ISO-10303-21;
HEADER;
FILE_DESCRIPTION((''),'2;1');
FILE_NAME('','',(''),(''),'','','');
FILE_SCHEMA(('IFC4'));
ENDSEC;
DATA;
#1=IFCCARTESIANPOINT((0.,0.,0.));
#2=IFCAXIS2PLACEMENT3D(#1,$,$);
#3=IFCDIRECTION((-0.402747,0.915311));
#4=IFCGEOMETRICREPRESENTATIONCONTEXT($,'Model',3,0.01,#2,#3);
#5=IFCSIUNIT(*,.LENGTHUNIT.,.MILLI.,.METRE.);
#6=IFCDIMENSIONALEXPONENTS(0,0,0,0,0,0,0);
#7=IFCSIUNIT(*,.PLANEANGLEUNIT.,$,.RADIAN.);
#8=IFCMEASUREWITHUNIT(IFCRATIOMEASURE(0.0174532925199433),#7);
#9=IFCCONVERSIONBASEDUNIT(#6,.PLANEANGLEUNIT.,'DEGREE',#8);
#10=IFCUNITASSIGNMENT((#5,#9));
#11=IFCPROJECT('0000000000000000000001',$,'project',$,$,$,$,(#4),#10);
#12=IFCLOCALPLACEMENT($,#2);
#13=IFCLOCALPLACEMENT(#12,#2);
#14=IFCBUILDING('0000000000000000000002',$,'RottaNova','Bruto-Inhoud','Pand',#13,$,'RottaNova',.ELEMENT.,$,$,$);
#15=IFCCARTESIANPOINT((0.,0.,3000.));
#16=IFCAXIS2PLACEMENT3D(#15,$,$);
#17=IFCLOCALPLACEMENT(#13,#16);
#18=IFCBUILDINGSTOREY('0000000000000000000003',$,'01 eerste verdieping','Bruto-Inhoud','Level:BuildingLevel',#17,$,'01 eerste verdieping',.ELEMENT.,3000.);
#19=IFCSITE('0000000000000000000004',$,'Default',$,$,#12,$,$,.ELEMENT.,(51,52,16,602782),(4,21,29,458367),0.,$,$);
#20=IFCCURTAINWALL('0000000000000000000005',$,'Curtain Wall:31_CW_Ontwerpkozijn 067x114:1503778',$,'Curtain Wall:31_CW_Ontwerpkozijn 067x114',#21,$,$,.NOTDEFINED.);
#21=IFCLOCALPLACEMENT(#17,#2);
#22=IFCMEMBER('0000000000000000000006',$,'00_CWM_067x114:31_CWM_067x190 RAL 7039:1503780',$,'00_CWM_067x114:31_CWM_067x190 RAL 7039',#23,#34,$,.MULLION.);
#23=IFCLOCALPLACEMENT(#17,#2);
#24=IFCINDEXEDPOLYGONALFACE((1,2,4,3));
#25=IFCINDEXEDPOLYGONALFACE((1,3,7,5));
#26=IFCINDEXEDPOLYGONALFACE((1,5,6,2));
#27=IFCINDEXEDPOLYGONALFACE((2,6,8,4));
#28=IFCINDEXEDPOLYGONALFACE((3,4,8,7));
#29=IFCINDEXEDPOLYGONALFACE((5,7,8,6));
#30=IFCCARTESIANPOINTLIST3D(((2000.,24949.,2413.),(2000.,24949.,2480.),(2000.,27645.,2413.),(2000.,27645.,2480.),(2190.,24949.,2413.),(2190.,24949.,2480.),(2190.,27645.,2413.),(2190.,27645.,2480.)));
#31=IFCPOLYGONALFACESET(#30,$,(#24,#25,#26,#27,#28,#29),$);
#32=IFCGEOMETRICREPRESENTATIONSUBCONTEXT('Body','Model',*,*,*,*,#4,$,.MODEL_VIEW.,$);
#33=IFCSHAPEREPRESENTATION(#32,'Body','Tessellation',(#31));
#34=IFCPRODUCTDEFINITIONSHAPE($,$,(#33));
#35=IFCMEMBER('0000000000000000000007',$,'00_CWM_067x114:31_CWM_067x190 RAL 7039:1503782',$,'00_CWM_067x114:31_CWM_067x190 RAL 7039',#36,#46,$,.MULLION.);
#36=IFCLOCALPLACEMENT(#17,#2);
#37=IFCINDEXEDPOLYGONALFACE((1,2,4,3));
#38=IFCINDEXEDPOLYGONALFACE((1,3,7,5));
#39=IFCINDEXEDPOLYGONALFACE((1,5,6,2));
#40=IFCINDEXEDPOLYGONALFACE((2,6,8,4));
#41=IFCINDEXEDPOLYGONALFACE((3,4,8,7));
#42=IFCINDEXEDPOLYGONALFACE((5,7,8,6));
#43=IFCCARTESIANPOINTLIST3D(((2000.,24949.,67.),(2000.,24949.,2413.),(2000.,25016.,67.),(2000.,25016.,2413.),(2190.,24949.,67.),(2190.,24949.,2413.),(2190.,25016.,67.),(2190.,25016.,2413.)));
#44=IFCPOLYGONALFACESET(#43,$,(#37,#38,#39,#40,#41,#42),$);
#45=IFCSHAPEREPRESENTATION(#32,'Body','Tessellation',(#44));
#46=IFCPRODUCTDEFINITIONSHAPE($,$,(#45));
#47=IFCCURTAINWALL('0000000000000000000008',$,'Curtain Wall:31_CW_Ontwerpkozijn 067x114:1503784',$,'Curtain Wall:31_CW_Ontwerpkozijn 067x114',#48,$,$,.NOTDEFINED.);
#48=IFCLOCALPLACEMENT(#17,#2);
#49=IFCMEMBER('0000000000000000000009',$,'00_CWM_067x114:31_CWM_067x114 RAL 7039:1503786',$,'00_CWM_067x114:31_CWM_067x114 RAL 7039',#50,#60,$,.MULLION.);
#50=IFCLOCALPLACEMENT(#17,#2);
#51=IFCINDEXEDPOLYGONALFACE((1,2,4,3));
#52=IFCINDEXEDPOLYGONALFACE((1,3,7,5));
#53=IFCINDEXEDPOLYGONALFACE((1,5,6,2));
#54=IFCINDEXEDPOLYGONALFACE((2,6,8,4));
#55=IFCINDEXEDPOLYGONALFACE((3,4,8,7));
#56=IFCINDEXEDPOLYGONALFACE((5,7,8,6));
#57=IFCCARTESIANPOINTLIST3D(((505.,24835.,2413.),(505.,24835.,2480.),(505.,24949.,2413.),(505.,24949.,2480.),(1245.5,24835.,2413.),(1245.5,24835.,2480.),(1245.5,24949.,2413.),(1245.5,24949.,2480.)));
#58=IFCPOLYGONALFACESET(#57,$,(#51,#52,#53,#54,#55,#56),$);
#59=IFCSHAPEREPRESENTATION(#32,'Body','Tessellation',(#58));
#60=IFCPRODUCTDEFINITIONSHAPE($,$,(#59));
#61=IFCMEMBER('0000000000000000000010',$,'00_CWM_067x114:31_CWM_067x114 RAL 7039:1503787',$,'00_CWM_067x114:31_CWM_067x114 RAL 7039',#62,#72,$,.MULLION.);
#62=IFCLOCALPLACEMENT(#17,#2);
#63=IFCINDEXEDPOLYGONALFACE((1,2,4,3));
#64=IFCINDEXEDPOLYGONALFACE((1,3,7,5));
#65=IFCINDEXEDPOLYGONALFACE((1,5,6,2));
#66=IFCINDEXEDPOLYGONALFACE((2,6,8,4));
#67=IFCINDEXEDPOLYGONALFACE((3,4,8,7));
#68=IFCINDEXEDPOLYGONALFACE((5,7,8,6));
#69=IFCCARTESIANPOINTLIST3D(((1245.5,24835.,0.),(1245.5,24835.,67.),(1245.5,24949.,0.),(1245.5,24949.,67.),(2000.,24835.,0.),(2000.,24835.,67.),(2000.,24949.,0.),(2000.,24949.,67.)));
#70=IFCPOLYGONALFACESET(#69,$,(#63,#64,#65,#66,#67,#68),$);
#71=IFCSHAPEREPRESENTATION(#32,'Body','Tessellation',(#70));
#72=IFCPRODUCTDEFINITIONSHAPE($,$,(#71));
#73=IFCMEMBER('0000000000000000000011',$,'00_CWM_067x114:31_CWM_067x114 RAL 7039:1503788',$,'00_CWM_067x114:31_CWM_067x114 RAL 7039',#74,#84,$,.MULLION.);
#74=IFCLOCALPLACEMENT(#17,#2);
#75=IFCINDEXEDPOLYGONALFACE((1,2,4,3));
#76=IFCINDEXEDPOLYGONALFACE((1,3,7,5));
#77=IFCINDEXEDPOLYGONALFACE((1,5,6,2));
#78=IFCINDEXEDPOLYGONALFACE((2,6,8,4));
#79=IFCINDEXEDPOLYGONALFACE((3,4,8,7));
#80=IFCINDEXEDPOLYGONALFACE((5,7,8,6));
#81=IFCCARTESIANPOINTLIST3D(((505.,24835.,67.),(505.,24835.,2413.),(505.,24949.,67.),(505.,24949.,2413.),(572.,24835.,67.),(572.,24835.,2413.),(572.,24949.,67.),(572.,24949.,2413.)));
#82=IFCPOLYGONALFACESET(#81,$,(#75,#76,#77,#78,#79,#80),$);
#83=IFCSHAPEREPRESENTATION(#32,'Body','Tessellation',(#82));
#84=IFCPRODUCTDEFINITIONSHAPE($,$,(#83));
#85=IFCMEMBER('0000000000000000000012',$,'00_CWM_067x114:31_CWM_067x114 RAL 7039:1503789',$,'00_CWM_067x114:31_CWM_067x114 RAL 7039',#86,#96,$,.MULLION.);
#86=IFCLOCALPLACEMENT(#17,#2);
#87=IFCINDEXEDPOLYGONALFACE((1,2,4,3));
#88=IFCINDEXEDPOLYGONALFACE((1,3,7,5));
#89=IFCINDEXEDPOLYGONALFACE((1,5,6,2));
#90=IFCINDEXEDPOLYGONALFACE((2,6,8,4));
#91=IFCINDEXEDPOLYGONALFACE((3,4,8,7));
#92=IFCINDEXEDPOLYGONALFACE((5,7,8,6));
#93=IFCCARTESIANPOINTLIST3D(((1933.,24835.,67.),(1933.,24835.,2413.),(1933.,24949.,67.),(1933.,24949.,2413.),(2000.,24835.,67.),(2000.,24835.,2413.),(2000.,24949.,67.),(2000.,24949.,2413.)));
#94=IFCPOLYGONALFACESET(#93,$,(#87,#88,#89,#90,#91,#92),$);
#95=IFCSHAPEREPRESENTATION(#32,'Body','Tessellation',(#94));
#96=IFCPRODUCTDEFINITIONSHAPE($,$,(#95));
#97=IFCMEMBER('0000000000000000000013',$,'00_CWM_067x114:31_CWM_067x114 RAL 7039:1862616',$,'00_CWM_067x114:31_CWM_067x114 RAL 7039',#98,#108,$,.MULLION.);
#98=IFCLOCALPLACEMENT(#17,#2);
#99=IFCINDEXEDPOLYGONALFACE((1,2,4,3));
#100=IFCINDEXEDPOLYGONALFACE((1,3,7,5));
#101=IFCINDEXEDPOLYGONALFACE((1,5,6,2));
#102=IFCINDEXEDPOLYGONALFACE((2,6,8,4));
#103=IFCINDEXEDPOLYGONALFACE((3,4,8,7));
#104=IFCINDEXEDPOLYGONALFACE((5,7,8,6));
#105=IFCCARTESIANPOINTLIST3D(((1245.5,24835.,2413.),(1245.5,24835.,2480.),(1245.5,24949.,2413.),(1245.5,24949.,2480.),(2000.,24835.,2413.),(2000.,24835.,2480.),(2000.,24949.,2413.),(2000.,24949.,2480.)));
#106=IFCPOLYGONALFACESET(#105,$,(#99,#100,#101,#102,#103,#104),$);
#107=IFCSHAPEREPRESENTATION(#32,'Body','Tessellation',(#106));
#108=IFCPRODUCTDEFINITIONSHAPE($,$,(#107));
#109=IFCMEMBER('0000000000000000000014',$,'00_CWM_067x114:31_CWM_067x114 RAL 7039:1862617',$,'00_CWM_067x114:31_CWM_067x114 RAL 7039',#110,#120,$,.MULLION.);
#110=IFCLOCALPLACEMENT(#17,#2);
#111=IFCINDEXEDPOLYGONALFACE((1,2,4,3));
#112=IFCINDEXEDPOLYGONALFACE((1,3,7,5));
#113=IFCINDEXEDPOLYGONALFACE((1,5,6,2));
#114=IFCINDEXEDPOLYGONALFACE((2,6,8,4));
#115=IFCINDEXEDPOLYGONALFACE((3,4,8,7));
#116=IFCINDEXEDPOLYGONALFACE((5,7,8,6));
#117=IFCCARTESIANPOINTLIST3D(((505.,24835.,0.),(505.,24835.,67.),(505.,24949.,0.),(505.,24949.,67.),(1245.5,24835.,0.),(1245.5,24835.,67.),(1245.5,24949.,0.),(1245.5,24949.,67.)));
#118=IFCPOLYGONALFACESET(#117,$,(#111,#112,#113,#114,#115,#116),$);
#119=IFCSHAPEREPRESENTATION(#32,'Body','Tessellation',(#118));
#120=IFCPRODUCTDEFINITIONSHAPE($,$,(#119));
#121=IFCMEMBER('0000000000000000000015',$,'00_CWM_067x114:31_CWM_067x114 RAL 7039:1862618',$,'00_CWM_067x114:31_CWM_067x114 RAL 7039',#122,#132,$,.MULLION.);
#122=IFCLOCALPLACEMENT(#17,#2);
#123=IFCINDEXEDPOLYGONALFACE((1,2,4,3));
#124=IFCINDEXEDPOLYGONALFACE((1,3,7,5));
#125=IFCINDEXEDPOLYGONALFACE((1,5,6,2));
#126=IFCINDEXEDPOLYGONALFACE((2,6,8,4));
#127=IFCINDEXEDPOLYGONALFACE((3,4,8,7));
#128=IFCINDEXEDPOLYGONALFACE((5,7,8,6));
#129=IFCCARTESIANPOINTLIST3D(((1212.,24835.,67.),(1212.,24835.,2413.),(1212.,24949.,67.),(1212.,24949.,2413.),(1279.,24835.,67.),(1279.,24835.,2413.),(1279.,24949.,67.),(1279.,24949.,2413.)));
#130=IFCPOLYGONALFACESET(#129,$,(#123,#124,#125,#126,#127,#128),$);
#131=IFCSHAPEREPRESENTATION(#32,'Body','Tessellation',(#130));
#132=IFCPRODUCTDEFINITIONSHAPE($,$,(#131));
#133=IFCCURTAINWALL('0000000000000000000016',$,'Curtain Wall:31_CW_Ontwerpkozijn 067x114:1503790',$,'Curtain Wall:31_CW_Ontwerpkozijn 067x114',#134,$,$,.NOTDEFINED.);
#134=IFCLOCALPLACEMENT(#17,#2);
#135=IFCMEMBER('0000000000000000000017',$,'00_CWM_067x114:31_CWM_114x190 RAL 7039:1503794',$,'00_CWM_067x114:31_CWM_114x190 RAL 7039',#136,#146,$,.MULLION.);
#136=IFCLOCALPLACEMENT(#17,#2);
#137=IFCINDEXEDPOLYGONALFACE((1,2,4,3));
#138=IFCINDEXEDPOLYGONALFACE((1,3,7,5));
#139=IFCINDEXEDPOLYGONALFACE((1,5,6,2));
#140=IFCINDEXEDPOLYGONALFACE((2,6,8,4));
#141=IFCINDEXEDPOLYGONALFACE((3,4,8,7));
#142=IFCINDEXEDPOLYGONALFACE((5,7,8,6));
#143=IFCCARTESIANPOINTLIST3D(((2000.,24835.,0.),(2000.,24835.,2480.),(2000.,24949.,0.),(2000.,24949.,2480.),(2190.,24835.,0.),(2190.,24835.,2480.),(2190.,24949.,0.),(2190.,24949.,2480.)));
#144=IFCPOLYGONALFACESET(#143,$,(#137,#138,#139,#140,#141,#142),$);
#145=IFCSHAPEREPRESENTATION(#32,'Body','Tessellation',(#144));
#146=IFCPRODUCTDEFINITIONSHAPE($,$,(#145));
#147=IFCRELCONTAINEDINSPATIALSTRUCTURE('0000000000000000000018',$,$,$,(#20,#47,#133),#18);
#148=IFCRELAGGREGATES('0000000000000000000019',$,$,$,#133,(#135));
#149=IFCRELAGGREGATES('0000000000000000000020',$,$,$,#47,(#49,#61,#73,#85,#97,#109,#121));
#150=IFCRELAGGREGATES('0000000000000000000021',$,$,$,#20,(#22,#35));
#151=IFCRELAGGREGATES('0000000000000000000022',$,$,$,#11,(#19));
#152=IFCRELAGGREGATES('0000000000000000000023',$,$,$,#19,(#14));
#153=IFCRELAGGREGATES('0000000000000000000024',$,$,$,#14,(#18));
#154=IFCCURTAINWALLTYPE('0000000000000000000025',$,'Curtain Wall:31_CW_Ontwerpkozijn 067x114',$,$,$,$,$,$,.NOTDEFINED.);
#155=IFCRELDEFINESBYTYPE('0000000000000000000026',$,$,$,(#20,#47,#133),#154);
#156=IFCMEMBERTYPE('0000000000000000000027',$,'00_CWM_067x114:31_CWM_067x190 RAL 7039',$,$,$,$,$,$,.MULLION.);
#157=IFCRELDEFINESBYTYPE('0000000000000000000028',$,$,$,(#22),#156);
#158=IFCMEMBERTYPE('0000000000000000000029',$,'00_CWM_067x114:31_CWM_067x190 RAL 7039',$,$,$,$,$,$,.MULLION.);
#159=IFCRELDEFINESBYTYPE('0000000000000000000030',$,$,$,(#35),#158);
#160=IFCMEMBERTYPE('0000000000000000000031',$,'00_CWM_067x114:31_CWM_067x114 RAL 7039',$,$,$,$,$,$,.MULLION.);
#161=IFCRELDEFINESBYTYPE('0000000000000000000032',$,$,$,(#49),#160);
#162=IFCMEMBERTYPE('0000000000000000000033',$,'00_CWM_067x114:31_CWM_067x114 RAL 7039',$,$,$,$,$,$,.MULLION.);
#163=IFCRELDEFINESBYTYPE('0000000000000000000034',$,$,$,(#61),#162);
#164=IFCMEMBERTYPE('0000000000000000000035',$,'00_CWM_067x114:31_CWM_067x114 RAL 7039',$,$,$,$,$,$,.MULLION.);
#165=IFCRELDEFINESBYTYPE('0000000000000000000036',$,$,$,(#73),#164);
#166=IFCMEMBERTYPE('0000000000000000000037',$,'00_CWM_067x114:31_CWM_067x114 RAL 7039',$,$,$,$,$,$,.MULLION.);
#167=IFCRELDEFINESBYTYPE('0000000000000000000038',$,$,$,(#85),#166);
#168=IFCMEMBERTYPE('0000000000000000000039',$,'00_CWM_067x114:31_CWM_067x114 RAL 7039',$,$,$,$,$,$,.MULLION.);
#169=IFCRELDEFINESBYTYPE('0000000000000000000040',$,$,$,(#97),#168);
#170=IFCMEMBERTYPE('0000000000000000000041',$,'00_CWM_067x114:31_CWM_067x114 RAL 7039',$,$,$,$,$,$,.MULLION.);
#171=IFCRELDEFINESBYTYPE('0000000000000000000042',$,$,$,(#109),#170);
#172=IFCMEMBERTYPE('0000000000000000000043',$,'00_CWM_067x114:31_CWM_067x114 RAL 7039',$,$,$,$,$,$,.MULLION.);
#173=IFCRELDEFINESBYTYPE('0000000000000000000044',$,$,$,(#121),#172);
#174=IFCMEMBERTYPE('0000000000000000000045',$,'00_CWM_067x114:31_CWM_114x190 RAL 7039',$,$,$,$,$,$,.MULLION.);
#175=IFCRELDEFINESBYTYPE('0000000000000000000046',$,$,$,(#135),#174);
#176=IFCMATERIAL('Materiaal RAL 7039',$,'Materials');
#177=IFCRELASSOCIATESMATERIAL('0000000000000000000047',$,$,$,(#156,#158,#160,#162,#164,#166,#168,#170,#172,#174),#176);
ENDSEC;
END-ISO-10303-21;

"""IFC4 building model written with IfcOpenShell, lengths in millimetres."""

from ifc_helpers import new_model, entity, si_unit, converted_unit, direction, frame, origin, origin_2d_with_axis, place, context, subcontext, project, spatial, rectangle, extrude, source, transform, mapped, material, material_profile, profile_set, type_object, type_shapes, element, aggregate, save


model = new_model("IFC4")

# Units and contexts
model_context = context("Model", 3, precision=0.01, world=origin(), true_north=direction((-0.402747, 0.915311)))
body_context = subcontext(model_context, "Body", "Model", "MODEL_VIEW")
ifc_project = project(units=[si_unit("LENGTHUNIT", "METRE", prefix="MILLI"), converted_unit("PLANEANGLEUNIT", "DEGREE", entity("IfcRatioMeasure", 0.0174532925199433), si_unit("PLANEANGLEUNIT", "RADIAN"), dimensions=[0, 0, 0, 0, 0, 0, 0])], contexts=[model_context])

# Site, building, storey
site_placement = place(None, origin())
site = spatial("IfcSite", under=ifc_project, at=site_placement, Name="Default", CompositionType="ELEMENT", RefLatitude=(51, 52, 16, 602782), RefLongitude=(4, 21, 29, 458367), RefElevation=0.0)
building_placement = place(site_placement, origin())
building = spatial("IfcBuilding", under=site, at=building_placement, Name="RottaNova", Description="Bruto-Inhoud", ObjectType="Pand", LongName="RottaNova", CompositionType="ELEMENT")
storey_placement = place(building_placement, frame((0.0, 0.0, 3000.0)))
storey = spatial("IfcBuildingStorey", under=building, at=storey_placement, Name="01 eerste verdieping", Description="Bruto-Inhoud", ObjectType="Level:BuildingLevel", LongName="01 eerste verdieping", CompositionType="ELEMENT", Elevation=3000.0)

# Curtain walls, members
curtain_wall_type = type_object("IfcCurtainWallType", Name="Curtain Wall:31_CW_Ontwerpkozijn 067x114", PredefinedType="NOTDEFINED")
curtain_wall_1_placement = place(storey_placement, frame((0.0, 0.0, -3000.0)))
curtain_wall_1 = element("IfcCurtainWall", 1, at=curtain_wall_1_placement, inside=storey, type_object=curtain_wall_type, Name="Curtain Wall:31_CW_Ontwerpkozijn 067x114:1503778", ObjectType="Curtain Wall:31_CW_Ontwerpkozijn 067x114", PredefinedType="NOTDEFINED")
ifc_material_1 = material(Name="Materiaal RAL 7039", Category="Materials")
ifc_material_profile_1 = material_profile(ifc_material_1, rectangle(XDim=190.0, YDim=67.0, at=origin_2d_with_axis()), Name="31_CWM_067x190 RAL 7039")
ifc_profile_set_1 = profile_set([ifc_material_profile_1], Name="31_CWM_067x190 RAL 7039")
member_type_1 = type_object("IfcMemberType", Name="00_CWM_067x114:31_CWM_067x190 RAL 7039", PredefinedType="MULLION", material=ifc_profile_set_1)
shared_shape_1 = source(origin(), body_context, "Body", "SweptSolid", [
    extrude(rectangle(XDim=190.0, YDim=67.0, at=origin_2d_with_axis()), frame((-33.5, 95.0, -2696.0), z_axis=(0.0, 0.0, 1.0), x_axis=(0.0, -1.0, 0.0)), (0.0, 0.0, 1.0), 2696.0),
])
type_shapes(member_type_1, [shared_shape_1])
member_1_placement = place(curtain_wall_1_placement, frame((2190.0, 24949.0, 5480.0), z_axis=(0.0, -1.0, 0.0), x_axis=(0.0, 0.0, 1.0)))
member_1 = element("IfcMember", 2, at=member_1_placement, type_object=member_type_1, Name="00_CWM_067x114:31_CWM_067x190 RAL 7039:1503780", ObjectType="00_CWM_067x114:31_CWM_067x190 RAL 7039", PredefinedType="MULLION", context=body_context, shape_type="MappedRepresentation", body=[
    mapped(shared_shape_1, transform((0.0, 0.0, 0.0), scale=1.0)),
])
member_type_2 = type_object("IfcMemberType", Name="00_CWM_067x114:31_CWM_067x190 RAL 7039", PredefinedType="MULLION", material=ifc_profile_set_1)
shared_shape_2 = source(origin(), body_context, "Body", "SweptSolid", [
    extrude(rectangle(XDim=190.0, YDim=67.0, at=origin_2d_with_axis()), frame((-33.5, 95.0, -2346.0), z_axis=(0.0, 0.0, 1.0), x_axis=(0.0, -1.0, 0.0)), (0.0, 0.0, 1.0), 2346.0),
])
type_shapes(member_type_2, [shared_shape_2])
member_2_placement = place(curtain_wall_1_placement, frame((2190.0, 24949.0, 3067.0), z_axis=(0.0, 0.0, -1.0), x_axis=(0.0, -1.0, 0.0)))
member_2 = element("IfcMember", 3, at=member_2_placement, type_object=member_type_2, Name="00_CWM_067x114:31_CWM_067x190 RAL 7039:1503782", ObjectType="00_CWM_067x114:31_CWM_067x190 RAL 7039", PredefinedType="MULLION", context=body_context, shape_type="MappedRepresentation", body=[
    mapped(shared_shape_2, transform((0.0, 0.0, 0.0), scale=1.0)),
])
curtain_wall_2_placement = place(storey_placement, frame((0.0, 0.0, -3000.0)))
curtain_wall_2 = element("IfcCurtainWall", 4, at=curtain_wall_2_placement, inside=storey, type_object=curtain_wall_type, Name="Curtain Wall:31_CW_Ontwerpkozijn 067x114:1503784", ObjectType="Curtain Wall:31_CW_Ontwerpkozijn 067x114", PredefinedType="NOTDEFINED")
ifc_material_profile_2 = material_profile(ifc_material_1, rectangle(XDim=114.0, YDim=67.0, at=origin_2d_with_axis()), Name="31_CWM_067x114 RAL 7039")
ifc_profile_set_2 = profile_set([ifc_material_profile_2], Name="31_CWM_067x114 RAL 7039")
member_type_3 = type_object("IfcMemberType", Name="00_CWM_067x114:31_CWM_067x114 RAL 7039", PredefinedType="MULLION", material=ifc_profile_set_2)
shared_shape_3 = source(origin(), body_context, "Body", "SweptSolid", [
    extrude(rectangle(XDim=114.0, YDim=67.0, at=origin_2d_with_axis()), frame((-33.5, 57.0, -740.5), z_axis=(0.0, 0.0, 1.0), x_axis=(0.0, -1.0, 0.0)), (0.0, 0.0, 1.0), 740.5),
])
type_shapes(member_type_3, [shared_shape_3])
member_3_placement = place(curtain_wall_2_placement, frame((505.0, 24835.0, 5480.0), z_axis=(-1.0, 0.0, 0.0), x_axis=(0.0, 0.0, 1.0)))
member_3 = element("IfcMember", 5, at=member_3_placement, type_object=member_type_3, Name="00_CWM_067x114:31_CWM_067x114 RAL 7039:1503786", ObjectType="00_CWM_067x114:31_CWM_067x114 RAL 7039", PredefinedType="MULLION", context=body_context, shape_type="MappedRepresentation", body=[
    mapped(shared_shape_3, transform((0.0, 0.0, 0.0), scale=1.0)),
])
member_type_4 = type_object("IfcMemberType", Name="00_CWM_067x114:31_CWM_067x114 RAL 7039", PredefinedType="MULLION", material=ifc_profile_set_2)
shared_shape_4 = source(origin(), body_context, "Body", "SweptSolid", [
    extrude(rectangle(XDim=114.0, YDim=67.0, at=origin_2d_with_axis()), frame((-33.5, 57.0, -754.5), z_axis=(0.0, 0.0, 1.0), x_axis=(0.0, -1.0, 0.0)), (0.0, 0.0, 1.0), 754.5),
])
type_shapes(member_type_4, [shared_shape_4])
member_4_placement = place(curtain_wall_2_placement, frame((2000.0, 24835.0, 3000.0), z_axis=(1.0, 0.0, 0.0), x_axis=(0.0, 0.0, -1.0)))
member_4 = element("IfcMember", 6, at=member_4_placement, type_object=member_type_4, Name="00_CWM_067x114:31_CWM_067x114 RAL 7039:1503787", ObjectType="00_CWM_067x114:31_CWM_067x114 RAL 7039", PredefinedType="MULLION", context=body_context, shape_type="MappedRepresentation", body=[
    mapped(shared_shape_4, transform((0.0, 0.0, 0.0), scale=1.0)),
])
member_type_5 = type_object("IfcMemberType", Name="00_CWM_067x114:31_CWM_067x114 RAL 7039", PredefinedType="MULLION", material=ifc_profile_set_2)
shared_shape_5 = source(origin(), body_context, "Body", "SweptSolid", [
    extrude(rectangle(XDim=114.0, YDim=67.0, at=origin_2d_with_axis()), frame((-33.5, 57.0, -2346.0), z_axis=(0.0, 0.0, 1.0), x_axis=(0.0, -1.0, 0.0)), (0.0, 0.0, 1.0), 2346.0),
])
type_shapes(member_type_5, [shared_shape_5])
member_5_placement = place(curtain_wall_2_placement, frame((505.0, 24835.0, 3067.0), z_axis=(0.0, 0.0, -1.0), x_axis=(-1.0, 0.0, 0.0)))
member_5 = element("IfcMember", 7, at=member_5_placement, type_object=member_type_5, Name="00_CWM_067x114:31_CWM_067x114 RAL 7039:1503788", ObjectType="00_CWM_067x114:31_CWM_067x114 RAL 7039", PredefinedType="MULLION", context=body_context, shape_type="MappedRepresentation", body=[
    mapped(shared_shape_5, transform((0.0, 0.0, 0.0), scale=1.0)),
])
member_type_6 = type_object("IfcMemberType", Name="00_CWM_067x114:31_CWM_067x114 RAL 7039", PredefinedType="MULLION", material=ifc_profile_set_2)
shared_shape_6 = source(origin(), body_context, "Body", "SweptSolid", [
    extrude(rectangle(XDim=114.0, YDim=67.0, at=origin_2d_with_axis()), frame((-33.5, 57.0, -2346.0), z_axis=(0.0, 0.0, 1.0), x_axis=(0.0, -1.0, 0.0)), (0.0, 0.0, 1.0), 2346.0),
])
type_shapes(member_type_6, [shared_shape_6])
member_6_placement = place(curtain_wall_2_placement, frame((2000.0, 24835.0, 5413.0)))
member_6 = element("IfcMember", 8, at=member_6_placement, type_object=member_type_6, Name="00_CWM_067x114:31_CWM_067x114 RAL 7039:1503789", ObjectType="00_CWM_067x114:31_CWM_067x114 RAL 7039", PredefinedType="MULLION", context=body_context, shape_type="MappedRepresentation", body=[
    mapped(shared_shape_6, transform((0.0, 0.0, 0.0), scale=1.0)),
])
member_type_7 = type_object("IfcMemberType", Name="00_CWM_067x114:31_CWM_067x114 RAL 7039", PredefinedType="MULLION", material=ifc_profile_set_2)
shared_shape_7 = source(origin(), body_context, "Body", "SweptSolid", [
    extrude(rectangle(XDim=114.0, YDim=67.0, at=origin_2d_with_axis()), frame((-33.5, 57.0, -754.5), z_axis=(0.0, 0.0, 1.0), x_axis=(0.0, -1.0, 0.0)), (0.0, 0.0, 1.0), 754.5),
])
type_shapes(member_type_7, [shared_shape_7])
member_7_placement = place(curtain_wall_2_placement, frame((1245.5, 24835.0, 5480.0), z_axis=(-1.0, 0.0, 0.0), x_axis=(0.0, 0.0, 1.0)))
member_7 = element("IfcMember", 9, at=member_7_placement, type_object=member_type_7, Name="00_CWM_067x114:31_CWM_067x114 RAL 7039:1862616", ObjectType="00_CWM_067x114:31_CWM_067x114 RAL 7039", PredefinedType="MULLION", context=body_context, shape_type="MappedRepresentation", body=[
    mapped(shared_shape_7, transform((0.0, 0.0, 0.0), scale=1.0)),
])
member_type_8 = type_object("IfcMemberType", Name="00_CWM_067x114:31_CWM_067x114 RAL 7039", PredefinedType="MULLION", material=ifc_profile_set_2)
shared_shape_8 = source(origin(), body_context, "Body", "SweptSolid", [
    extrude(rectangle(XDim=114.0, YDim=67.0, at=origin_2d_with_axis()), frame((-33.5, 57.0, -740.5), z_axis=(0.0, 0.0, 1.0), x_axis=(0.0, -1.0, 0.0)), (0.0, 0.0, 1.0), 740.5),
])
type_shapes(member_type_8, [shared_shape_8])
member_8_placement = place(curtain_wall_2_placement, frame((1245.5, 24835.0, 3000.0), z_axis=(1.0, 0.0, 0.0), x_axis=(0.0, 0.0, -1.0)))
member_8 = element("IfcMember", 10, at=member_8_placement, type_object=member_type_8, Name="00_CWM_067x114:31_CWM_067x114 RAL 7039:1862617", ObjectType="00_CWM_067x114:31_CWM_067x114 RAL 7039", PredefinedType="MULLION", context=body_context, shape_type="MappedRepresentation", body=[
    mapped(shared_shape_8, transform((0.0, 0.0, 0.0), scale=1.0)),
])
member_type_9 = type_object("IfcMemberType", Name="00_CWM_067x114:31_CWM_067x114 RAL 7039", PredefinedType="MULLION", material=ifc_profile_set_2)
shared_shape_9 = source(origin(), body_context, "Body", "SweptSolid", [
    extrude(rectangle(XDim=114.0, YDim=67.0, at=origin_2d_with_axis()), frame((0.0, 57.0, -2346.0), z_axis=(0.0, 0.0, 1.0), x_axis=(0.0, -1.0, 0.0)), (0.0, 0.0, 1.0), 2346.0),
])
type_shapes(member_type_9, [shared_shape_9])
member_9_placement = place(curtain_wall_2_placement, frame((1245.5, 24835.0, 3067.0), z_axis=(0.0, 0.0, -1.0), x_axis=(-1.0, 0.0, 0.0)))
member_9 = element("IfcMember", 11, at=member_9_placement, type_object=member_type_9, Name="00_CWM_067x114:31_CWM_067x114 RAL 7039:1862618", ObjectType="00_CWM_067x114:31_CWM_067x114 RAL 7039", PredefinedType="MULLION", context=body_context, shape_type="MappedRepresentation", body=[
    mapped(shared_shape_9, transform((0.0, 0.0, 0.0), scale=1.0)),
])

# Curtain wall, member
curtain_wall_3_placement = place(storey_placement, frame((0.0, 0.0, -3000.0)))
curtain_wall_3 = element("IfcCurtainWall", 12, at=curtain_wall_3_placement, inside=storey, type_object=curtain_wall_type, Name="Curtain Wall:31_CW_Ontwerpkozijn 067x114:1503790", ObjectType="Curtain Wall:31_CW_Ontwerpkozijn 067x114", PredefinedType="NOTDEFINED")
ifc_material_profile_3 = material_profile(ifc_material_1, rectangle(XDim=114.0, YDim=190.0, at=origin_2d_with_axis()), Name="31_CWM_114x190 RAL 7039")
ifc_profile_set_3 = profile_set([ifc_material_profile_3], Name="31_CWM_114x190 RAL 7039")
member_type_10 = type_object("IfcMemberType", Name="00_CWM_067x114:31_CWM_114x190 RAL 7039", PredefinedType="MULLION", material=ifc_profile_set_3)
shared_shape_10 = source(origin(), body_context, "Body", "SweptSolid", [
    extrude(rectangle(XDim=114.0, YDim=190.0, at=origin_2d_with_axis()), frame((-95.0, 0.0, -2480.0), z_axis=(0.0, 0.0, 1.0), x_axis=(0.0, -1.0, 0.0)), (0.0, 0.0, 1.0), 2480.0),
])
type_shapes(member_type_10, [shared_shape_10])
member_10_placement = place(curtain_wall_3_placement, frame((2190.0, 24892.0, 5480.0)))
member_10 = element("IfcMember", 13, at=member_10_placement, type_object=member_type_10, Name="00_CWM_067x114:31_CWM_114x190 RAL 7039:1503794", ObjectType="00_CWM_067x114:31_CWM_114x190 RAL 7039", PredefinedType="MULLION", context=body_context, shape_type="MappedRepresentation", body=[
    mapped(shared_shape_10, transform((0.0, 0.0, 0.0), scale=1.0)),
])
aggregate(curtain_wall_3, [member_10])

aggregate(curtain_wall_2, [member_3, member_4, member_5, member_6, member_7, member_8, member_9])

aggregate(curtain_wall_1, [member_1, member_2])

save(model, "model.ifc")
